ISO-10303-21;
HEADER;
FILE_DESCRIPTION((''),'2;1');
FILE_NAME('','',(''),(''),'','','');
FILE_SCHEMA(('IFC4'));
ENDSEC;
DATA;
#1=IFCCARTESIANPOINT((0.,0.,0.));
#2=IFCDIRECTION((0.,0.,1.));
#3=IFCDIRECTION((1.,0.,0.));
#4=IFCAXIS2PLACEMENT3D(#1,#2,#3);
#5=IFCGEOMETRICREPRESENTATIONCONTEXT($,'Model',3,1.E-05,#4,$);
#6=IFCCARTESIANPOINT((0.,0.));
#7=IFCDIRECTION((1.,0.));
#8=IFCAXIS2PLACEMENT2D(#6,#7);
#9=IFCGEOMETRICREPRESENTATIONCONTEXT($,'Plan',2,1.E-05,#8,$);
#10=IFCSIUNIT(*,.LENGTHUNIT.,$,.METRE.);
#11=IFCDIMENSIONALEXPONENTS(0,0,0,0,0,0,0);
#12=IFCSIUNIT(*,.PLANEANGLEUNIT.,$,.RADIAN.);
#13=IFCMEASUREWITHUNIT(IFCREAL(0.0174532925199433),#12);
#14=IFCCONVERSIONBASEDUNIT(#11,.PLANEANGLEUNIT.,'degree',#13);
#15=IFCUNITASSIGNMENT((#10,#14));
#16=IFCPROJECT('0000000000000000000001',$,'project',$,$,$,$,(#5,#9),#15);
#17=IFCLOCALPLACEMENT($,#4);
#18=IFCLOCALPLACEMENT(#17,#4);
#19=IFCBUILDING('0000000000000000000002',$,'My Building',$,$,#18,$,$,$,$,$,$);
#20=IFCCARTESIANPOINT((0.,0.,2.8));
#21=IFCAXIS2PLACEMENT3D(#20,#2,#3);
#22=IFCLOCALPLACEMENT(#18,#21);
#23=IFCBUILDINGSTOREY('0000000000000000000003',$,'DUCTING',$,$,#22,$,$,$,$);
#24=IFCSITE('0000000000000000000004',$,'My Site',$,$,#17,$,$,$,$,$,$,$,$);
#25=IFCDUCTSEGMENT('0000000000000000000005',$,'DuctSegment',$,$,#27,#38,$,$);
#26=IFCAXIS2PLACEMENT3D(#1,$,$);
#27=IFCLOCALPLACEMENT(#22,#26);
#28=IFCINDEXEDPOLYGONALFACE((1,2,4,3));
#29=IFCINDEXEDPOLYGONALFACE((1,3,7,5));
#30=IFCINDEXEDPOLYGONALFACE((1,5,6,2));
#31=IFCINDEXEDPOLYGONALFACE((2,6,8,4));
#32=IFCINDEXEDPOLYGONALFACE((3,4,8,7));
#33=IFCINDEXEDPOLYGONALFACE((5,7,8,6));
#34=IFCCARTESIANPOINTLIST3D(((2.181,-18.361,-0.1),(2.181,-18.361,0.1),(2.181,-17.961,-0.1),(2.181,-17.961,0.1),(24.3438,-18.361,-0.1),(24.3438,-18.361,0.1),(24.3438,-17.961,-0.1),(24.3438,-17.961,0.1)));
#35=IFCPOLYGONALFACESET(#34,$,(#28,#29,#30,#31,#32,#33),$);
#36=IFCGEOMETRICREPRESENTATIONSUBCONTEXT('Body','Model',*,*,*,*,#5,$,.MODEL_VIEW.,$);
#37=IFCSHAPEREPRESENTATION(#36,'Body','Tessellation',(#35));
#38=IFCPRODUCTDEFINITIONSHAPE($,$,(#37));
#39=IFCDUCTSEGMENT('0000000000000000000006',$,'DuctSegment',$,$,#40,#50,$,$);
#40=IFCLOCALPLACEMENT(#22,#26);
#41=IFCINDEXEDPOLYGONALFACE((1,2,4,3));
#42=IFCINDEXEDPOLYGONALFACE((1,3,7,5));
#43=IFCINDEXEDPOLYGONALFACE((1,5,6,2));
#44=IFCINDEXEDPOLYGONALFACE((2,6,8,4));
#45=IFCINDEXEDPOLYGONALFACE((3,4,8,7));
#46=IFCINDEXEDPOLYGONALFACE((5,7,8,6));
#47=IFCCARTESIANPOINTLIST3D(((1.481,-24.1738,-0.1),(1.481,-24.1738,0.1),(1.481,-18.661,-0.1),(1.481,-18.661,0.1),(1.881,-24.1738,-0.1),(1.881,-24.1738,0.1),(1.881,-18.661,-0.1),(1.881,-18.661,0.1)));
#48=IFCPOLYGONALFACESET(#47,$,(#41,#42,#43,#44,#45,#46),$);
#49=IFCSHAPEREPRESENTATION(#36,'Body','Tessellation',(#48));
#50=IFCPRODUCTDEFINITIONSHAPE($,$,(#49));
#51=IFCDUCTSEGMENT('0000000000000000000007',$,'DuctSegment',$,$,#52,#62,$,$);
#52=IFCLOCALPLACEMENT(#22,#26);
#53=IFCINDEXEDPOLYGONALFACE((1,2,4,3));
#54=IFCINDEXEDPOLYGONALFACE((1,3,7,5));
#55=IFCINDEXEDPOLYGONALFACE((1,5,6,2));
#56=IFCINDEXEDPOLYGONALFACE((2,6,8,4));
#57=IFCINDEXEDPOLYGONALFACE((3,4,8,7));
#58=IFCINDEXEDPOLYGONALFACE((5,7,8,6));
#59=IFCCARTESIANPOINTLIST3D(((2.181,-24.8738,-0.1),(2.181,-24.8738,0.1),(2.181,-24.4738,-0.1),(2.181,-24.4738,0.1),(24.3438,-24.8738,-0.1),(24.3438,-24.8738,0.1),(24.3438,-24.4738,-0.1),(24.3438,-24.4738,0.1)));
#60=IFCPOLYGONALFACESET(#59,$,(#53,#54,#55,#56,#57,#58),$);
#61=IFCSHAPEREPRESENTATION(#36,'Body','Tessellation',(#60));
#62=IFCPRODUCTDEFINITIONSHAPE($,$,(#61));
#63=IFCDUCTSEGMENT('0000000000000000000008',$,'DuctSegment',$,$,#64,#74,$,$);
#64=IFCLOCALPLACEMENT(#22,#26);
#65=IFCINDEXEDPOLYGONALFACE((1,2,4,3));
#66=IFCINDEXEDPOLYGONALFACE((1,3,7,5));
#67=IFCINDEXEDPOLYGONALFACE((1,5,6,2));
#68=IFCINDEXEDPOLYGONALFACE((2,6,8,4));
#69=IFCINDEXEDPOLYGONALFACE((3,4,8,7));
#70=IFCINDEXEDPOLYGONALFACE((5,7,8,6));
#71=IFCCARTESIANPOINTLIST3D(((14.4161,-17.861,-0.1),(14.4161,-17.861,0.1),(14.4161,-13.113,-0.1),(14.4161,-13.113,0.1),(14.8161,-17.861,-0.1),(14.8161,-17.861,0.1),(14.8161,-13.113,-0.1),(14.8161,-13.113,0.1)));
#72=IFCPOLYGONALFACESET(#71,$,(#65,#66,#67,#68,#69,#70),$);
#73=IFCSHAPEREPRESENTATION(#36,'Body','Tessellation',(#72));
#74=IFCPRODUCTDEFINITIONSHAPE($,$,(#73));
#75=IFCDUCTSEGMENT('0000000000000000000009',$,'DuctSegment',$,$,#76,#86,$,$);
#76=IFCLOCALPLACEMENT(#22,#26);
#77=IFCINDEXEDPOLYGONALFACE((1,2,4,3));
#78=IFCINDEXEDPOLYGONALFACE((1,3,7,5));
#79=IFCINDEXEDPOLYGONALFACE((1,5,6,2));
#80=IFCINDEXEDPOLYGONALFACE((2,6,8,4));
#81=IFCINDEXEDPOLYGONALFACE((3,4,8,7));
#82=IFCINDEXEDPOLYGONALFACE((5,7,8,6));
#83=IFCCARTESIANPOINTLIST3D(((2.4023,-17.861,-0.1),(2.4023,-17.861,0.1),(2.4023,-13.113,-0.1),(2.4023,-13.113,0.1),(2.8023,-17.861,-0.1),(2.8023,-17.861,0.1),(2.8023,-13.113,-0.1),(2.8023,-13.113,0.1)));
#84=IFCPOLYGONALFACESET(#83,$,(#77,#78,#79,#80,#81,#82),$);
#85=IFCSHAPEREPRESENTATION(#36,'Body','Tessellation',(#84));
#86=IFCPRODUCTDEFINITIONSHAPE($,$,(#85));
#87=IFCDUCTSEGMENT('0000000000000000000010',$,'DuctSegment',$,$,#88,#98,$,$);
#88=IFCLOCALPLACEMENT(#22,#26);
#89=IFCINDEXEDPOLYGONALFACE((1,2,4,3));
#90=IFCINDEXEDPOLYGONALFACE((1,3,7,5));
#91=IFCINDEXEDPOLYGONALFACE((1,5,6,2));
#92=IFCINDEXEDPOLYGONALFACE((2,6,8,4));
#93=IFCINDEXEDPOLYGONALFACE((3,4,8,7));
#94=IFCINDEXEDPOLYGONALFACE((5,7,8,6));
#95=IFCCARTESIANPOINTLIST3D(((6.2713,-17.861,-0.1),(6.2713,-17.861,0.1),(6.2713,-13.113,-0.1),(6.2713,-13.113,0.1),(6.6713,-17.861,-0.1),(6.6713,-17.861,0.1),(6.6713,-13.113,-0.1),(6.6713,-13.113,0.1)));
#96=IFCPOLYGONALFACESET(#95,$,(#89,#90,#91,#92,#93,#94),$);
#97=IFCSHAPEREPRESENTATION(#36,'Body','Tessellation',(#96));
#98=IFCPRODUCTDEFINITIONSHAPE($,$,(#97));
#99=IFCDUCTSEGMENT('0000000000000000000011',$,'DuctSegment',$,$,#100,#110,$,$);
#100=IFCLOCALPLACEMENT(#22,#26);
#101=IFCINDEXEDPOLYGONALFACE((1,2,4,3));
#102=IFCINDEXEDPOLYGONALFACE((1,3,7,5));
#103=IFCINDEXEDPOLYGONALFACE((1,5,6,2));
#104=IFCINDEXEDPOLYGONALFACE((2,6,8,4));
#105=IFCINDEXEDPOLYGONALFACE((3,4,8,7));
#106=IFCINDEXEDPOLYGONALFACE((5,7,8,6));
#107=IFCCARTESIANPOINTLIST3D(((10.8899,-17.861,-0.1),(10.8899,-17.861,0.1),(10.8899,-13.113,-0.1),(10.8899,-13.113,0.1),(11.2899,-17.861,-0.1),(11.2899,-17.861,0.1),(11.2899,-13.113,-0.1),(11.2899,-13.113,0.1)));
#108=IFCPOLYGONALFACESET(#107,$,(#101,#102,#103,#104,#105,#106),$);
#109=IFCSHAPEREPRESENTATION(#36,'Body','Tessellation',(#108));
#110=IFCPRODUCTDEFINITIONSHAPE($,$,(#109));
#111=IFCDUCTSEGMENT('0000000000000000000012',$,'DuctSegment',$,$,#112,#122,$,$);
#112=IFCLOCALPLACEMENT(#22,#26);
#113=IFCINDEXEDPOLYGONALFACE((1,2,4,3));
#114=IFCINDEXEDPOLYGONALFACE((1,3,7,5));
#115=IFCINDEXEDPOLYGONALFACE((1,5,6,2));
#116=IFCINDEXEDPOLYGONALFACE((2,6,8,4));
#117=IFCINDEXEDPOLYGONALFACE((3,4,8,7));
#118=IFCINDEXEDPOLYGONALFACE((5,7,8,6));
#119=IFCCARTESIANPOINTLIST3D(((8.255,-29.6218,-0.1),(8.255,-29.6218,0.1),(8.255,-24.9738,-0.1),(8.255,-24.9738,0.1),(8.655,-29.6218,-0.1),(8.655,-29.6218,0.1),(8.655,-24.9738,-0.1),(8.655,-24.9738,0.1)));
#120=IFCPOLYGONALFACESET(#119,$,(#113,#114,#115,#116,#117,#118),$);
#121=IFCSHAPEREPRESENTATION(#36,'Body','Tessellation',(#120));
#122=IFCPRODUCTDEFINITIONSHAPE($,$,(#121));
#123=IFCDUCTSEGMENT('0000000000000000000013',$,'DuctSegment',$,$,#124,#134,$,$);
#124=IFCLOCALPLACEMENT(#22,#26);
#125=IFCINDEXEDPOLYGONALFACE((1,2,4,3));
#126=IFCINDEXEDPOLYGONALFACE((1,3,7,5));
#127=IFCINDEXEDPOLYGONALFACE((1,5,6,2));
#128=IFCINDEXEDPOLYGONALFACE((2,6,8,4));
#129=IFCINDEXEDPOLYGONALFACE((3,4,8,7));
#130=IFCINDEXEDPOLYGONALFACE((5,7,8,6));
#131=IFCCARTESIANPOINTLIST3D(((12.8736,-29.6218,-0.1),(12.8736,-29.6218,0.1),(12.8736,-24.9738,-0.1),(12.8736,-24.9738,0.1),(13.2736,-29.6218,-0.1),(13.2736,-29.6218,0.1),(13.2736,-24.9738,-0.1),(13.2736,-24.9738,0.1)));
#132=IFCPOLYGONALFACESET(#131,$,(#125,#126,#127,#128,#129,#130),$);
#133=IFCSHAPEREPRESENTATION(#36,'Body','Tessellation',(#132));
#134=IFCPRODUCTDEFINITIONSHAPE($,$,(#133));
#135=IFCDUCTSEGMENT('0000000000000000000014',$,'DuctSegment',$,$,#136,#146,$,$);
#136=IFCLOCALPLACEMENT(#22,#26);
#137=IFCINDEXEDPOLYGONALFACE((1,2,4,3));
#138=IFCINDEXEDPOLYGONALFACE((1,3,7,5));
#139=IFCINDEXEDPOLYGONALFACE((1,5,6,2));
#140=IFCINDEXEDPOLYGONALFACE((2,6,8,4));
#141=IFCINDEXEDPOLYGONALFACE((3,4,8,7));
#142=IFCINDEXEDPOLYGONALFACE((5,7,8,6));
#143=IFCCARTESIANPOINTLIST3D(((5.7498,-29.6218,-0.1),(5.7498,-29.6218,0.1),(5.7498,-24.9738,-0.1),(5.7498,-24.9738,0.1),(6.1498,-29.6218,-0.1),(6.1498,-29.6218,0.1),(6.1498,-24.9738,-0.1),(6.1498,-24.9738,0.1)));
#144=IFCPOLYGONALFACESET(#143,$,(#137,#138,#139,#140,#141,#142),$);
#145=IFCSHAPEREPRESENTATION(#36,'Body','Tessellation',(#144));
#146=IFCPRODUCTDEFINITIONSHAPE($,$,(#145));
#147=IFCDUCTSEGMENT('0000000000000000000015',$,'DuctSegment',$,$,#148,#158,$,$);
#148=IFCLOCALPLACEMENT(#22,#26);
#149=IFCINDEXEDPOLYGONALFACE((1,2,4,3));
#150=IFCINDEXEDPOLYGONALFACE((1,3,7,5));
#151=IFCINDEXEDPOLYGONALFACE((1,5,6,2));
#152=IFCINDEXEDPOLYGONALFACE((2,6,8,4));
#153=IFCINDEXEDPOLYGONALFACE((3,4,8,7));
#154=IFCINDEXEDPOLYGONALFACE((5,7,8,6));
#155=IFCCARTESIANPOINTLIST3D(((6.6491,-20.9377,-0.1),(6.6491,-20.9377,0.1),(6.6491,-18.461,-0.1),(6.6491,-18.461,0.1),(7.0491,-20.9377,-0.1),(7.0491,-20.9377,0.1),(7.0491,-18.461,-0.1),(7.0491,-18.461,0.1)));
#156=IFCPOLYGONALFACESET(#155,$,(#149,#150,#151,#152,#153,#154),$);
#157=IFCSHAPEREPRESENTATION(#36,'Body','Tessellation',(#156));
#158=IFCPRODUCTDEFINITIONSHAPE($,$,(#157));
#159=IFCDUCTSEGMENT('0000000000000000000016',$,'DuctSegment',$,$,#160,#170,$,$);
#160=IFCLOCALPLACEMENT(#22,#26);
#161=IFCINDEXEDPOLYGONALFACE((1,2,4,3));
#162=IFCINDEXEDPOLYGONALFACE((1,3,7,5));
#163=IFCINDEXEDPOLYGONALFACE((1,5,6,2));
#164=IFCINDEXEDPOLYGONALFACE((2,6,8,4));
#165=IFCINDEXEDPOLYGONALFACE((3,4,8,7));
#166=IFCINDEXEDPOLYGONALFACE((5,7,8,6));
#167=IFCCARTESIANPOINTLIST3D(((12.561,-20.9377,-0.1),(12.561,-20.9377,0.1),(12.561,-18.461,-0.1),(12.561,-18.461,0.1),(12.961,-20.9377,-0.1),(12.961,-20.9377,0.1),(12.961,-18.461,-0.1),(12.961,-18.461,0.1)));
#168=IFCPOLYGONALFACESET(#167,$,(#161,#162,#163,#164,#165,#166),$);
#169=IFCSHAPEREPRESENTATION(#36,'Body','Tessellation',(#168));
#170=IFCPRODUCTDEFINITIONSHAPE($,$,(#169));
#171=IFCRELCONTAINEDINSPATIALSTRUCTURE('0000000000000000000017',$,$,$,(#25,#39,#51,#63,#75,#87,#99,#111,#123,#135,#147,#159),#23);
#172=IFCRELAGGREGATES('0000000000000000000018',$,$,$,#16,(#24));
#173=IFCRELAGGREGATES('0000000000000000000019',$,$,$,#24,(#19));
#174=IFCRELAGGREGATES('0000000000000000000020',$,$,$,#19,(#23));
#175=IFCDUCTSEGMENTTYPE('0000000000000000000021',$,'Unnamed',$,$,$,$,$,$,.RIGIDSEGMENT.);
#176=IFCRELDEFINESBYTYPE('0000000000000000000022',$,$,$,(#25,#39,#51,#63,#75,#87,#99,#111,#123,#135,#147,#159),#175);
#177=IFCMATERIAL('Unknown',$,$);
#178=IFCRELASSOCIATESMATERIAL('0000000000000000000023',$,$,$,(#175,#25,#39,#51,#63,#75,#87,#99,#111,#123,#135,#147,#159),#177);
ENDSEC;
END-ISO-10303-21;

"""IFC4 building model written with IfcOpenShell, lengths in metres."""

from ifc_helpers import new_model, entity, si_unit, converted_unit, frame, origin_with_axes, origin_2d_with_axis, place, context, subcontext, project, spatial, rectangle, extrude, material, material_profile, profile_set, profile_usage, type_object, element, save


model = new_model("IFC4")

# Units and contexts
model_context = context("Model", 3, precision=1e-05, world=origin_with_axes())
plan_context = context("Plan", 2, precision=1e-05, world=origin_2d_with_axis())
body_context = subcontext(model_context, "Body", "Model", "MODEL_VIEW")
ifc_project = project(units=[si_unit("LENGTHUNIT", "METRE"), converted_unit("PLANEANGLEUNIT", "degree", entity("IfcReal", 0.0174532925199433), si_unit("PLANEANGLEUNIT", "RADIAN"), dimensions=[0, 0, 0, 0, 0, 0, 0])], contexts=[model_context, plan_context])

# Site, building, storey
site_placement = place(None, origin_with_axes())
site = spatial("IfcSite", under=ifc_project, at=site_placement, Name="My Site")
building_placement = place(site_placement, origin_with_axes())
building = spatial("IfcBuilding", under=site, at=building_placement, Name="My Building")
storey_placement = place(building_placement, frame((0.0, 0.0, 2.8), z_axis=(0.0, 0.0, 1.0), x_axis=(1.0, 0.0, 0.0)))
storey = spatial("IfcBuildingStorey", under=building, at=storey_placement, Name="DUCTING")

# Duct segments
ifc_material = material(Name="Unknown")
ifc_material_profile_1 = material_profile(ifc_material, rectangle(XDim=0.4, YDim=0.2))
ifc_profile_set_1 = profile_set([ifc_material_profile_1])
ifc_profile_usage_1 = profile_usage(ifc_profile_set_1, cardinal=5)
duct_segment_type = type_object("IfcDuctSegmentType", Name="Unnamed", PredefinedType="RIGIDSEGMENT", material=ifc_profile_set_1)
duct_segment_1_placement = place(storey_placement, frame((2.181, -18.161, 0.0), z_axis=(1.0, 0.0, 0.0), x_axis=(0.0, 1.0, 0.0)))
element("IfcDuctSegment", 1, at=duct_segment_1_placement, inside=storey, type_object=duct_segment_type, material=ifc_profile_usage_1, Name="DuctSegment", context=body_context, shape_type="SweptSolid", body=[
    extrude(rectangle(XDim=0.4, YDim=0.2), origin_with_axes(), (0.0, 0.0, 1.0), 22.1628),
])
ifc_profile_usage_2 = profile_usage(ifc_profile_set_1, cardinal=5)
duct_segment_2_placement = place(storey_placement, frame((1.681, -18.661, 0.0), z_axis=(0.0, -1.0, 0.0), x_axis=(1.0, 0.0, 0.0)))
element("IfcDuctSegment", 2, at=duct_segment_2_placement, inside=storey, type_object=duct_segment_type, material=ifc_profile_usage_2, Name="DuctSegment", context=body_context, shape_type="SweptSolid", body=[
    extrude(rectangle(XDim=0.4, YDim=0.2), origin_with_axes(), (0.0, 0.0, 1.0), 5.5127),
])
ifc_profile_usage_3 = profile_usage(ifc_profile_set_1, cardinal=5)
duct_segment_3_placement = place(storey_placement, frame((2.181, -24.6738, 0.0), z_axis=(1.0, 0.0, 0.0), x_axis=(0.0, 1.0, 0.0)))
element("IfcDuctSegment", 3, at=duct_segment_3_placement, inside=storey, type_object=duct_segment_type, material=ifc_profile_usage_3, Name="DuctSegment", context=body_context, shape_type="SweptSolid", body=[
    extrude(rectangle(XDim=0.4, YDim=0.2), origin_with_axes(), (0.0, 0.0, 1.0), 22.1628),
])
ifc_profile_usage_4 = profile_usage(ifc_profile_set_1, cardinal=5)
duct_segment_4_placement = place(storey_placement, frame((14.6161, -17.861, 0.0), z_axis=(0.0, 1.0, 0.0), x_axis=(-1.0, 0.0, 0.0)))
element("IfcDuctSegment", 4, at=duct_segment_4_placement, inside=storey, type_object=duct_segment_type, material=ifc_profile_usage_4, Name="DuctSegment", context=body_context, shape_type="SweptSolid", body=[
    extrude(rectangle(XDim=0.4, YDim=0.2), origin_with_axes(), (0.0, 0.0, 1.0), 4.7481),
])
ifc_profile_usage_5 = profile_usage(ifc_profile_set_1, cardinal=5)
duct_segment_5_placement = place(storey_placement, frame((2.6023, -17.861, 0.0), z_axis=(0.0, 1.0, 0.0), x_axis=(-1.0, 0.0, 0.0)))
element("IfcDuctSegment", 5, at=duct_segment_5_placement, inside=storey, type_object=duct_segment_type, material=ifc_profile_usage_5, Name="DuctSegment", context=body_context, shape_type="SweptSolid", body=[
    extrude(rectangle(XDim=0.4, YDim=0.2), origin_with_axes(), (0.0, 0.0, 1.0), 4.7481),
])
ifc_profile_usage_6 = profile_usage(ifc_profile_set_1, cardinal=5)
duct_segment_6_placement = place(storey_placement, frame((6.4713, -17.861, 0.0), z_axis=(0.0, 1.0, 0.0), x_axis=(-1.0, 0.0, 0.0)))
element("IfcDuctSegment", 6, at=duct_segment_6_placement, inside=storey, type_object=duct_segment_type, material=ifc_profile_usage_6, Name="DuctSegment", context=body_context, shape_type="SweptSolid", body=[
    extrude(rectangle(XDim=0.4, YDim=0.2), origin_with_axes(), (0.0, 0.0, 1.0), 4.7481),
])
ifc_profile_usage_7 = profile_usage(ifc_profile_set_1, cardinal=5)
duct_segment_7_placement = place(storey_placement, frame((11.0899, -17.861, 0.0), z_axis=(0.0, 1.0, 0.0), x_axis=(-1.0, 0.0, 0.0)))
element("IfcDuctSegment", 7, at=duct_segment_7_placement, inside=storey, type_object=duct_segment_type, material=ifc_profile_usage_7, Name="DuctSegment", context=body_context, shape_type="SweptSolid", body=[
    extrude(rectangle(XDim=0.4, YDim=0.2), origin_with_axes(), (0.0, 0.0, 1.0), 4.7481),
])
ifc_profile_usage_8 = profile_usage(ifc_profile_set_1, cardinal=5)
duct_segment_8_placement = place(storey_placement, frame((8.455, -24.9738, 0.0), z_axis=(0.0, -1.0, 0.0), x_axis=(1.0, 0.0, 0.0)))
element("IfcDuctSegment", 8, at=duct_segment_8_placement, inside=storey, type_object=duct_segment_type, material=ifc_profile_usage_8, Name="DuctSegment", context=body_context, shape_type="SweptSolid", body=[
    extrude(rectangle(XDim=0.4, YDim=0.2), origin_with_axes(), (0.0, 0.0, 1.0), 4.6481),
])
ifc_profile_usage_9 = profile_usage(ifc_profile_set_1, cardinal=5)
duct_segment_9_placement = place(storey_placement, frame((13.0736, -24.9738, 0.0), z_axis=(0.0, -1.0, 0.0), x_axis=(1.0, 0.0, 0.0)))
element("IfcDuctSegment", 9, at=duct_segment_9_placement, inside=storey, type_object=duct_segment_type, material=ifc_profile_usage_9, Name="DuctSegment", context=body_context, shape_type="SweptSolid", body=[
    extrude(rectangle(XDim=0.4, YDim=0.2), origin_with_axes(), (0.0, 0.0, 1.0), 4.6481),
])
ifc_profile_usage_10 = profile_usage(ifc_profile_set_1, cardinal=5)
duct_segment_10_placement = place(storey_placement, frame((5.9498, -24.9738, 0.0), z_axis=(0.0, -1.0, 0.0), x_axis=(1.0, 0.0, 0.0)))
element("IfcDuctSegment", 10, at=duct_segment_10_placement, inside=storey, type_object=duct_segment_type, material=ifc_profile_usage_10, Name="DuctSegment", context=body_context, shape_type="SweptSolid", body=[
    extrude(rectangle(XDim=0.4, YDim=0.2), origin_with_axes(), (0.0, 0.0, 1.0), 4.6481),
])
ifc_profile_usage_11 = profile_usage(ifc_profile_set_1, cardinal=5)
duct_segment_11_placement = place(storey_placement, frame((6.8491, -18.461, 0.0), z_axis=(0.0, -1.0, 0.0), x_axis=(1.0, 0.0, 0.0)))
element("IfcDuctSegment", 11, at=duct_segment_11_placement, inside=storey, type_object=duct_segment_type, material=ifc_profile_usage_11, Name="DuctSegment", context=body_context, shape_type="SweptSolid", body=[
    extrude(rectangle(XDim=0.4, YDim=0.2), origin_with_axes(), (0.0, 0.0, 1.0), 2.4767),
])
ifc_profile_usage_12 = profile_usage(ifc_profile_set_1, cardinal=5)
duct_segment_12_placement = place(storey_placement, frame((12.761, -18.461, 0.0), z_axis=(0.0, -1.0, 0.0), x_axis=(1.0, 0.0, 0.0)))
element("IfcDuctSegment", 12, at=duct_segment_12_placement, inside=storey, type_object=duct_segment_type, material=ifc_profile_usage_12, Name="DuctSegment", context=body_context, shape_type="SweptSolid", body=[
    extrude(rectangle(XDim=0.4, YDim=0.2), origin_with_axes(), (0.0, 0.0, 1.0), 2.4767),
])

save(model, "model.ifc")
